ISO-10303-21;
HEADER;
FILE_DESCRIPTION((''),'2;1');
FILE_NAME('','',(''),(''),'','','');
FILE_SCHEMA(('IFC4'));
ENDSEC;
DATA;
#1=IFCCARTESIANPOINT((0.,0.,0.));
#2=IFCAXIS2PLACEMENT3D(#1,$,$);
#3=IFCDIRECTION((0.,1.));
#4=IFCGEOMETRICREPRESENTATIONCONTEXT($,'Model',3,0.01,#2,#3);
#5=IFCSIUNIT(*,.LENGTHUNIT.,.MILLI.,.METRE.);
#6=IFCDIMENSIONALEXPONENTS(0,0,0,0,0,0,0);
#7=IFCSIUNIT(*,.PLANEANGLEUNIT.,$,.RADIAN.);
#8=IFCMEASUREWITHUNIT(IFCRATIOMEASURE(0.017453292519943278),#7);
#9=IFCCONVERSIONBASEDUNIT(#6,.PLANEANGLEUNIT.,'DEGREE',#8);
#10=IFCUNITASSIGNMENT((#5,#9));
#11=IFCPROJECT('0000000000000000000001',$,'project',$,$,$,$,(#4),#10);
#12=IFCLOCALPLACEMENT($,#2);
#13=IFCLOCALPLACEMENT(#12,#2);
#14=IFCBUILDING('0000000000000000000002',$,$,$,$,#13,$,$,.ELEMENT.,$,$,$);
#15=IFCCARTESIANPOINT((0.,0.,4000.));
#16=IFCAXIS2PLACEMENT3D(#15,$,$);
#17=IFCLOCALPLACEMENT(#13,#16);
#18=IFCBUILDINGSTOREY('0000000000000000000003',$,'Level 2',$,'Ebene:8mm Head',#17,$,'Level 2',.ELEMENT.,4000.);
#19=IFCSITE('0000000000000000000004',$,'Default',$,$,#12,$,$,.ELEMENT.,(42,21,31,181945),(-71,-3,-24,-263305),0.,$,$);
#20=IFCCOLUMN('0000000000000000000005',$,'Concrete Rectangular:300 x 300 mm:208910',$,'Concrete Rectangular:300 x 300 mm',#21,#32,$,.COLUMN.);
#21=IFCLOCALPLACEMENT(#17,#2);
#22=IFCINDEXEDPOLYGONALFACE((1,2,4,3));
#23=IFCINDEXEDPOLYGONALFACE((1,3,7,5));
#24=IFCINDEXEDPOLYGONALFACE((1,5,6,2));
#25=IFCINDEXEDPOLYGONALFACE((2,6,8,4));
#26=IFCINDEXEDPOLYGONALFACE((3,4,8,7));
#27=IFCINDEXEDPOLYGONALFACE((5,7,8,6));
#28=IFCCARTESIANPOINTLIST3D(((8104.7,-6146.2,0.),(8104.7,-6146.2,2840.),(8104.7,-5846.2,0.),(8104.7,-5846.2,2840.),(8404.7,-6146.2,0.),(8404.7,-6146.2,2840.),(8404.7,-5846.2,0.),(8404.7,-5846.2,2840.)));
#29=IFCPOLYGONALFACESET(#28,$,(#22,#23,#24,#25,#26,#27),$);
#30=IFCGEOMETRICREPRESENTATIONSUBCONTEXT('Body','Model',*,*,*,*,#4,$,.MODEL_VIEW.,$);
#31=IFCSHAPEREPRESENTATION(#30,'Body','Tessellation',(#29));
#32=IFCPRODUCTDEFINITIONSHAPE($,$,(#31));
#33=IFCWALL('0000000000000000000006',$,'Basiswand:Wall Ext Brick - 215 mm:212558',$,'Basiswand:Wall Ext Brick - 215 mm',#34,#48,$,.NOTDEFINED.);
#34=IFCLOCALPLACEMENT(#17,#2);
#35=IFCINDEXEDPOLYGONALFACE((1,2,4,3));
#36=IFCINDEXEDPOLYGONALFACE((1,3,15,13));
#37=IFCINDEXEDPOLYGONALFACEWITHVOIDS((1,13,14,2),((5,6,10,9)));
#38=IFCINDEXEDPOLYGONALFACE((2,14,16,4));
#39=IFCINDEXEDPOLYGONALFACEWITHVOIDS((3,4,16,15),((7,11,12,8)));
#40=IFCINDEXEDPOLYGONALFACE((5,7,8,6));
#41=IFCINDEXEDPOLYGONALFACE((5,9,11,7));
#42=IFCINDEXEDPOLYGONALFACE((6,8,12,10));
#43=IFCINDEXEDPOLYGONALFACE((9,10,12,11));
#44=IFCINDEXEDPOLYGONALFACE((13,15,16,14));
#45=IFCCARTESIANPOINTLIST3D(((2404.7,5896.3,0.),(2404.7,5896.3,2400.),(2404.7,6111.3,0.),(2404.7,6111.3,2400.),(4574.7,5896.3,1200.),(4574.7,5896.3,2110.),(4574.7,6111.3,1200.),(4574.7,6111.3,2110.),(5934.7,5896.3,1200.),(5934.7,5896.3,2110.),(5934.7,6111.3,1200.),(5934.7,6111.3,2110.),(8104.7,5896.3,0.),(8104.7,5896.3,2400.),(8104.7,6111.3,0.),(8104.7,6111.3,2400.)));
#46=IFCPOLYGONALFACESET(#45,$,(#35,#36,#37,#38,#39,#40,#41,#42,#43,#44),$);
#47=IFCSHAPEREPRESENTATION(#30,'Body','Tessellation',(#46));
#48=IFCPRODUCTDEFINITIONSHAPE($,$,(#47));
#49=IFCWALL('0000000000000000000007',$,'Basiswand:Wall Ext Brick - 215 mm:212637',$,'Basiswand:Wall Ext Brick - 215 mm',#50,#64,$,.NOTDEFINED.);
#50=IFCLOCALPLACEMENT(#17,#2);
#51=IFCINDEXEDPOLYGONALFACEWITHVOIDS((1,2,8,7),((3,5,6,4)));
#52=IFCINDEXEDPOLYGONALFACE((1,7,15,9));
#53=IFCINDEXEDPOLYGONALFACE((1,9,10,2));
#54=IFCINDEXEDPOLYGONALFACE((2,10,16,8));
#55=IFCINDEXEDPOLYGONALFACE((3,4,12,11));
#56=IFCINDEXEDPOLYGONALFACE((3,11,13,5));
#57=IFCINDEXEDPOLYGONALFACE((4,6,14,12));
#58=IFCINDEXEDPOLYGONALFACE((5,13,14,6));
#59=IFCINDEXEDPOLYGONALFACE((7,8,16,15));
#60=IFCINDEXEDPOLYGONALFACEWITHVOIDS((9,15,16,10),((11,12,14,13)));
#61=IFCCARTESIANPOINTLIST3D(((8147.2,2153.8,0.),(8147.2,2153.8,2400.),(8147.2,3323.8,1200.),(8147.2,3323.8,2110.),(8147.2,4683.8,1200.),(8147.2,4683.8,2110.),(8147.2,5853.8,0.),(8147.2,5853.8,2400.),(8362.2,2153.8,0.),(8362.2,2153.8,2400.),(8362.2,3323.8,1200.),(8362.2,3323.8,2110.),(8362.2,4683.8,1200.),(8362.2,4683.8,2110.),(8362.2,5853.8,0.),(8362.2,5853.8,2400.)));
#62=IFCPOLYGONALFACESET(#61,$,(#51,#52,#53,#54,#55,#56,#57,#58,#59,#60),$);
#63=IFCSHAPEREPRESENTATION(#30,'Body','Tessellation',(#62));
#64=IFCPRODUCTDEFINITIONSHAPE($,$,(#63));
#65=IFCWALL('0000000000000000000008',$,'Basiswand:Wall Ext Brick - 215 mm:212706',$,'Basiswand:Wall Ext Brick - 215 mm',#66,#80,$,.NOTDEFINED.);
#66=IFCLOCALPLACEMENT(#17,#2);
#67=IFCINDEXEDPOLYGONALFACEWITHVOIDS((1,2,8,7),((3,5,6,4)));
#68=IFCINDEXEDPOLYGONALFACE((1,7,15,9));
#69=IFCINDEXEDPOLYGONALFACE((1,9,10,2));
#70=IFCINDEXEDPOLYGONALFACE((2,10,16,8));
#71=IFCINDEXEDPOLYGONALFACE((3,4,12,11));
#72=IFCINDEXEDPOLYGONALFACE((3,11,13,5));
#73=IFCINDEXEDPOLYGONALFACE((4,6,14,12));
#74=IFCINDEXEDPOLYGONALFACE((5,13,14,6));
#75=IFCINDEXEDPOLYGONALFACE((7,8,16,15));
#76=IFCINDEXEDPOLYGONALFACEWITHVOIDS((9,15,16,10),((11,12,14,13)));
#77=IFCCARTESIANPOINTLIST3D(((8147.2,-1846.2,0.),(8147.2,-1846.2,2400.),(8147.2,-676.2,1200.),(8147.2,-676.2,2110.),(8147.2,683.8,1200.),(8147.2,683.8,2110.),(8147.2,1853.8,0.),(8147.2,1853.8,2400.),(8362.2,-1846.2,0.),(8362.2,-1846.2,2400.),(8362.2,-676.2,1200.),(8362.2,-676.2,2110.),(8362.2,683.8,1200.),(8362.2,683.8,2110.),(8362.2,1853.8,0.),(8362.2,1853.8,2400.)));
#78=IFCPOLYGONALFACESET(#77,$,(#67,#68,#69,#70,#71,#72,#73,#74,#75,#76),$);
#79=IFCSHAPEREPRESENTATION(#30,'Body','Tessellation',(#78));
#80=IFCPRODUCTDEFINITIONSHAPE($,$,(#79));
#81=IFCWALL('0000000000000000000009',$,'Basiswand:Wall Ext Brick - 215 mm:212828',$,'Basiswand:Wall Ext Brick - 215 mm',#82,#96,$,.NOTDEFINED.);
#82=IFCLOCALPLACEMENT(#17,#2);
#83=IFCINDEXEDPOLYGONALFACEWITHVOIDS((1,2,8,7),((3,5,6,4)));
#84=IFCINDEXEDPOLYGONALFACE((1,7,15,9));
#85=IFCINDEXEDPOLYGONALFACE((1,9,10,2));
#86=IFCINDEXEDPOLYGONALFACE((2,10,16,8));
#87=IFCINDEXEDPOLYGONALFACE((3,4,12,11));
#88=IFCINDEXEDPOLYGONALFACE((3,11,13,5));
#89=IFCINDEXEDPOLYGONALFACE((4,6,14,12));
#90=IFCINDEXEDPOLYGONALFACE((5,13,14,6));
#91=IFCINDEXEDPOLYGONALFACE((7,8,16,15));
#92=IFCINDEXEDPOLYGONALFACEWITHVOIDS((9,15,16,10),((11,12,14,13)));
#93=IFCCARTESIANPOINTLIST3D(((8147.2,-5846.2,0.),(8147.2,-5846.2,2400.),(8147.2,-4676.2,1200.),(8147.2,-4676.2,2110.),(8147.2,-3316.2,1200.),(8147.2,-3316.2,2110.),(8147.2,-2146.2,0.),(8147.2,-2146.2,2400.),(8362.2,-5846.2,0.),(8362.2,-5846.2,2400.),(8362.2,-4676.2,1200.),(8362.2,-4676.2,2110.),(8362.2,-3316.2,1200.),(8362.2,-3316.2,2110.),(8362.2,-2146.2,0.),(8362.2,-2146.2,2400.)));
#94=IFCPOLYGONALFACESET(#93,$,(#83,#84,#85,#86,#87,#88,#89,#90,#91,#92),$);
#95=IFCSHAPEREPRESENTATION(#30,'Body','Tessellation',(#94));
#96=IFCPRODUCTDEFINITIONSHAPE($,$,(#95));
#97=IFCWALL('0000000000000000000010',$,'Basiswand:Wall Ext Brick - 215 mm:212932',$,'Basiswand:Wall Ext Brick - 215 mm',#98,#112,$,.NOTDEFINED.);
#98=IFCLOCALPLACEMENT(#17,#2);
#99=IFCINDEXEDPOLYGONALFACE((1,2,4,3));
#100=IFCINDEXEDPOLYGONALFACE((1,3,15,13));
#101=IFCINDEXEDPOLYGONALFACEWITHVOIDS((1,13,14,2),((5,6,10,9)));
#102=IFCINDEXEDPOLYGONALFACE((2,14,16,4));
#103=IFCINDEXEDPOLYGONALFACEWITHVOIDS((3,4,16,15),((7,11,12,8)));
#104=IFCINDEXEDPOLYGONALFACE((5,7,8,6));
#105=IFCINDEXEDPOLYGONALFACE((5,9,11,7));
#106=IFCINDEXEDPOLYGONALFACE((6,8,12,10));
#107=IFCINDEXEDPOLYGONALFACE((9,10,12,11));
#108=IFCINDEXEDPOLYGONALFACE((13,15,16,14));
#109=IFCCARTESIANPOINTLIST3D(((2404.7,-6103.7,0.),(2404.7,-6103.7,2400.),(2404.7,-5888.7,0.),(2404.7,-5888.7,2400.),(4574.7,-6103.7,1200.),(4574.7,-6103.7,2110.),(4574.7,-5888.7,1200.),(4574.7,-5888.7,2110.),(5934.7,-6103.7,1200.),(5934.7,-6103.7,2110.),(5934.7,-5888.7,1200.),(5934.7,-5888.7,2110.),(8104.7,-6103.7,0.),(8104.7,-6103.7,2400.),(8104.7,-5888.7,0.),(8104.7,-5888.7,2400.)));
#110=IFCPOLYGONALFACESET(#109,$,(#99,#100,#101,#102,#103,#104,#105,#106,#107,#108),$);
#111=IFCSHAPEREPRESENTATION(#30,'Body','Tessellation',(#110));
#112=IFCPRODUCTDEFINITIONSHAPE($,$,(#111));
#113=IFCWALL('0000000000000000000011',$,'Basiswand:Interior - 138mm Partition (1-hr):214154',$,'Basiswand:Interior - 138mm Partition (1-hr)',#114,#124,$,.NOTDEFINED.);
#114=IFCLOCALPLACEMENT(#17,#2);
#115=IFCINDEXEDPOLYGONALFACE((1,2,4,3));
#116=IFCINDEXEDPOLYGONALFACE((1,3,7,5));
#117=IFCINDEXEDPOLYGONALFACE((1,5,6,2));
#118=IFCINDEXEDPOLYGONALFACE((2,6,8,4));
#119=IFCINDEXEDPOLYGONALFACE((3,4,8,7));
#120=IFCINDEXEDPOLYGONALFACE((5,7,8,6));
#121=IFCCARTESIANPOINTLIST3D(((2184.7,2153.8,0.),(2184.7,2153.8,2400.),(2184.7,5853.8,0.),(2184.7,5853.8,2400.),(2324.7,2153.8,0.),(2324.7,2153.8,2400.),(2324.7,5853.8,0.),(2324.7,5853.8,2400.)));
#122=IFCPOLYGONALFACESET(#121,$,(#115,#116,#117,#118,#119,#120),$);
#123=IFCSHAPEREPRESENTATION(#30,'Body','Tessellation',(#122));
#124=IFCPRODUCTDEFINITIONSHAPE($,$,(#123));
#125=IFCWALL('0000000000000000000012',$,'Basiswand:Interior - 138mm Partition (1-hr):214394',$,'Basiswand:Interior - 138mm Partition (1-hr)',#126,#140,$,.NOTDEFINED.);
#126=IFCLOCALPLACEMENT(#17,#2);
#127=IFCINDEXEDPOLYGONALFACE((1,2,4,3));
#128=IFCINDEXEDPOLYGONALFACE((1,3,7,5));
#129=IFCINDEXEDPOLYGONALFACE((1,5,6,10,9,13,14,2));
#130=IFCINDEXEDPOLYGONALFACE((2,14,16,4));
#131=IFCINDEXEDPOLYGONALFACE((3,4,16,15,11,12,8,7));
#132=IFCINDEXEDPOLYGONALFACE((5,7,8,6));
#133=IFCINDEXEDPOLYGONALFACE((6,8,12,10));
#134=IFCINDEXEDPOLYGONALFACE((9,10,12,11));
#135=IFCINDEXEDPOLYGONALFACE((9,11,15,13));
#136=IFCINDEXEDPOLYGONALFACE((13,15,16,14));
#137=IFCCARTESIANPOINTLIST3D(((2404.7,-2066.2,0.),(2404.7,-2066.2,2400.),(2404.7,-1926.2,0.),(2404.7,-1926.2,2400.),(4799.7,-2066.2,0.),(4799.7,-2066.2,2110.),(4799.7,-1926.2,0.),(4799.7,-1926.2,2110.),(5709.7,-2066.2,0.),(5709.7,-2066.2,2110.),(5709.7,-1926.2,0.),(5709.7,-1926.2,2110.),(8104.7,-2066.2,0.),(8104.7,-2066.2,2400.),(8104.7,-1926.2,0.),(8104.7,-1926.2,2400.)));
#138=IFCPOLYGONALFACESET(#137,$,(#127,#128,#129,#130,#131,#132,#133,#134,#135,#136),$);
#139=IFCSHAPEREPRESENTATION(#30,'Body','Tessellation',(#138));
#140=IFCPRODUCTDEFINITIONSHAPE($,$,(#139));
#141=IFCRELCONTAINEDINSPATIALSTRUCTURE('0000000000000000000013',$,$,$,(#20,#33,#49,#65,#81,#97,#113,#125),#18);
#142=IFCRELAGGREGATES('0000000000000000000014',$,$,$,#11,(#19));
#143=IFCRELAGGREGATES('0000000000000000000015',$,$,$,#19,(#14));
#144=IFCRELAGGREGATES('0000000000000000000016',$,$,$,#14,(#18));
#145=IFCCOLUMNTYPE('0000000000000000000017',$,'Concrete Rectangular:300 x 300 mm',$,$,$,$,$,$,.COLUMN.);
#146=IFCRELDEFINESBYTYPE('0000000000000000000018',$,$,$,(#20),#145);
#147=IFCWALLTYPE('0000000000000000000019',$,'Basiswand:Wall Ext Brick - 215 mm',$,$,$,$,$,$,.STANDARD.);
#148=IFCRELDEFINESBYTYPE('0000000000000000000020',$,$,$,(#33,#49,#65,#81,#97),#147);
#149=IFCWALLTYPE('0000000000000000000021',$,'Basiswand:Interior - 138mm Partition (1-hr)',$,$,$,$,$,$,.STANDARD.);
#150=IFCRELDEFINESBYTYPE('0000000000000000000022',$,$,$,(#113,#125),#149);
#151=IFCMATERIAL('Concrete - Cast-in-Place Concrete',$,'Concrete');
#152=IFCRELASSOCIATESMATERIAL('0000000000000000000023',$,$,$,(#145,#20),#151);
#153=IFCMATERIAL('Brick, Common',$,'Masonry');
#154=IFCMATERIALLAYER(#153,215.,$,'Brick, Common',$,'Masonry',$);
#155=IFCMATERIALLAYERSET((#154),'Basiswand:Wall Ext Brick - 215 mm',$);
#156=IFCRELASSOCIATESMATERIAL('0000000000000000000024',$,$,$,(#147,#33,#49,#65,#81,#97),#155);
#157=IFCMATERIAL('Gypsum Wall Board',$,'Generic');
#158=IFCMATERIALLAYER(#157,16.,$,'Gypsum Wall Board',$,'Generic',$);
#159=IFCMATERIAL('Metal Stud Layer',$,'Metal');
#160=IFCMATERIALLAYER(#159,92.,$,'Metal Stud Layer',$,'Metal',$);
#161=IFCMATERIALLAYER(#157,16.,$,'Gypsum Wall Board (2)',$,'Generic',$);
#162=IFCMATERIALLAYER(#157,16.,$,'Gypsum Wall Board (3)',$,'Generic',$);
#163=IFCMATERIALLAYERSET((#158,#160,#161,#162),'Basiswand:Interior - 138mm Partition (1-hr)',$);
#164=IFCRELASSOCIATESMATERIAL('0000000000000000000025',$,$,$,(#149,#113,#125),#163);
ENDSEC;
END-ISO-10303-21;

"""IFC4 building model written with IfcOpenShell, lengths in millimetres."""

from ifc_helpers import new_model, entity, si_unit, converted_unit, direction, frame, frame_2d, origin, place, context, subcontext, project, spatial, polyline, segment, composite_curve, rectangle, outline, extrude, source, transform, mapped, material, layer, layer_set, layer_usage, material_profile, profile_set, profile_usage, type_object, type_shapes, element, save


model = new_model("IFC4")

# Units and contexts
model_context = context("Model", 3, precision=0.01, world=origin(), true_north=direction((0.0, 1.0)))
body_context = subcontext(model_context, "Body", "Model", "MODEL_VIEW")
ifc_project = project(units=[si_unit("LENGTHUNIT", "METRE", prefix="MILLI"), converted_unit("PLANEANGLEUNIT", "DEGREE", entity("IfcRatioMeasure", 0.017453292519943278), si_unit("PLANEANGLEUNIT", "RADIAN"), dimensions=[0, 0, 0, 0, 0, 0, 0])], contexts=[model_context])

# Site, building, storey
site_placement = place(None, origin())
site = spatial("IfcSite", under=ifc_project, at=site_placement, Name="Default", CompositionType="ELEMENT", RefLatitude=(42, 21, 31, 181945), RefLongitude=(-71, -3, -24, -263305), RefElevation=0.0)
building_placement = place(site_placement, origin())
building = spatial("IfcBuilding", under=site, at=building_placement, CompositionType="ELEMENT")
storey_placement = place(building_placement, frame((0.0, 0.0, 4000.0)))
storey = spatial("IfcBuildingStorey", under=building, at=storey_placement, Name="Level 2", ObjectType="Ebene:8mm Head", LongName="Level 2", CompositionType="ELEMENT", Elevation=4000.0)

# Column
ifc_material_1 = material(Name="Concrete - Cast-in-Place Concrete", Category="Concrete")
ifc_material_profile_1 = material_profile(ifc_material_1, outline(composite_curve([segment(polyline([(150.0, 150.0, 0.0), (150.0, -150.0, 0.0)]), True, "CONTINUOUS"), segment(polyline([(150.0, -150.0, 0.0), (-150.0, -150.0, 0.0)]), True, "CONTINUOUS"), segment(polyline([(-150.0, -150.0, 0.0), (-150.0, 150.0, 0.0)]), True, "CONTINUOUS"), segment(polyline([(-150.0, 150.0, 0.0), (150.0, 150.0, 0.0)]), True, "CONTINUOUS")], self_intersect=False), kind="CURVE"), Name="300 x 300 mm")
ifc_material_profile_2 = material_profile(ifc_material_1, outline(composite_curve([segment(polyline([(150.0, 150.0, 4000.0), (-150.0, 150.0, 4000.0)]), True, "CONTINUOUS"), segment(polyline([(-150.0, 150.0, 4000.0), (-150.0, -150.0, 4000.0)]), True, "CONTINUOUS"), segment(polyline([(-150.0, -150.0, 4000.0), (150.0, -150.0, 4000.0)]), True, "CONTINUOUS"), segment(polyline([(150.0, -150.0, 4000.0), (150.0, 150.0, 4000.0)]), True, "CONTINUOUS")], self_intersect=False), kind="CURVE"), Name="300 x 300 mm")
ifc_profile_set = profile_set([ifc_material_profile_1, ifc_material_profile_2], Name="300 x 300 mm")
ifc_profile_usage_1 = profile_usage(ifc_profile_set)
column_type_1 = type_object("IfcColumnType", Name="Concrete Rectangular:300 x 300 mm", PredefinedType="COLUMN", material=ifc_profile_set)
shared_shape_1 = source(origin(), body_context, "Body", "SweptSolid", [
    extrude(rectangle(XDim=300.0, YDim=300.0, at=frame_2d((0.0, 0.0), x_axis=(1.0, 0.0))), frame((8254.7, -5996.2, 4000.0), z_axis=(0.0, 0.0, 1.0), x_axis=(0.0, -1.0, 0.0)), (0.0, 0.0, 1.0), 2840.0),
])
type_shapes(column_type_1, [shared_shape_1])
column_1_placement = place(storey_placement, frame((0.0, 0.0, -4000.0)))
element("IfcColumn", 1, at=column_1_placement, inside=storey, type_object=column_type_1, material=ifc_profile_usage_1, Name="Concrete Rectangular:300 x 300 mm:208910", ObjectType="Concrete Rectangular:300 x 300 mm", PredefinedType="COLUMN", context=body_context, shape_type="MappedRepresentation", body=[
    mapped(shared_shape_1, transform((0.0, 0.0, 0.0), scale=1.0)),
])

# Walls, openings
ifc_material_2 = material(Name="Brick, Common", Category="Masonry")
ifc_layer_1 = layer(ifc_material_2, 215.0, Name="Brick, Common", Category="Masonry")
ifc_layer_set_1 = layer_set([ifc_layer_1], Name="Basiswand:Wall Ext Brick - 215 mm")
ifc_layer_usage_1 = layer_usage(ifc_layer_set_1, "AXIS2", "NEGATIVE", 107.5)
wall_type_1 = type_object("IfcWallType", Name="Basiswand:Wall Ext Brick - 215 mm", PredefinedType="STANDARD", material=ifc_layer_set_1)
wall_1_placement = place(storey_placement, frame((2404.7, 6003.8, 0.0)))
wall_1 = element("IfcWall", 2, at=wall_1_placement, inside=storey, type_object=wall_type_1, material=ifc_layer_usage_1, Name="Basiswand:Wall Ext Brick - 215 mm:212558", ObjectType="Basiswand:Wall Ext Brick - 215 mm", PredefinedType="NOTDEFINED", context=body_context, shape_type="SweptSolid", body=[
    extrude(rectangle(XDim=5700.0, YDim=215.0, at=frame_2d((2850.0, 0.0), x_axis=(-1.0, 0.0))), origin(), (0.0, 0.0, 1.0), 2400.0),
])
opening_1_placement = place(wall_1_placement, frame((2170.0, -107.5, 1200.0)))
element("IfcOpeningElement", 3, at=opening_1_placement, cuts=wall_1, PredefinedType="OPENING", context=body_context, shape_type="SweptSolid", body=[
    extrude(rectangle(XDim=910.0, YDim=1360.0, at=frame_2d((455.0, 680.0), x_axis=(-1.0, 0.0))), frame((0.0, 0.0, 0.0), z_axis=(0.0, 1.0, 0.0), x_axis=(0.0, 0.0, 1.0)), (0.0, 0.0, 1.0), 215.0),
])
ifc_layer_usage_2 = layer_usage(ifc_layer_set_1, "AXIS2", "NEGATIVE", 107.5)
wall_2_placement = place(storey_placement, frame((8254.7, 5853.8, 0.0), z_axis=(0.0, 0.0, 1.0), x_axis=(0.0, -1.0, 0.0)))
wall_2 = element("IfcWall", 4, at=wall_2_placement, inside=storey, type_object=wall_type_1, material=ifc_layer_usage_2, Name="Basiswand:Wall Ext Brick - 215 mm:212637", ObjectType="Basiswand:Wall Ext Brick - 215 mm", PredefinedType="NOTDEFINED", context=body_context, shape_type="SweptSolid", body=[
    extrude(rectangle(XDim=3700.0, YDim=215.0, at=frame_2d((1850.0, 0.0), x_axis=(-1.0, 0.0))), origin(), (0.0, 0.0, 1.0), 2400.0),
])
opening_2_placement = place(wall_2_placement, frame((1170.0, -107.5, 1200.0)))
element("IfcOpeningElement", 5, at=opening_2_placement, cuts=wall_2, PredefinedType="OPENING", context=body_context, shape_type="SweptSolid", body=[
    extrude(rectangle(XDim=910.0, YDim=1360.0, at=frame_2d((455.0, 680.0), x_axis=(-1.0, 0.0))), frame((0.0, 0.0, 0.0), z_axis=(0.0, 1.0, 0.0), x_axis=(0.0, 0.0, 1.0)), (0.0, 0.0, 1.0), 215.0),
])
ifc_layer_usage_3 = layer_usage(ifc_layer_set_1, "AXIS2", "NEGATIVE", 107.5)
wall_3_placement = place(storey_placement, frame((8254.7, 1853.8, 0.0), z_axis=(0.0, 0.0, 1.0), x_axis=(0.0, -1.0, 0.0)))
wall_3 = element("IfcWall", 6, at=wall_3_placement, inside=storey, type_object=wall_type_1, material=ifc_layer_usage_3, Name="Basiswand:Wall Ext Brick - 215 mm:212706", ObjectType="Basiswand:Wall Ext Brick - 215 mm", PredefinedType="NOTDEFINED", context=body_context, shape_type="SweptSolid", body=[
    extrude(rectangle(XDim=3700.0, YDim=215.0, at=frame_2d((1850.0, 0.0), x_axis=(-1.0, 0.0))), origin(), (0.0, 0.0, 1.0), 2400.0),
])
opening_3_placement = place(wall_3_placement, frame((1170.0, -107.5, 1200.0)))
element("IfcOpeningElement", 7, at=opening_3_placement, cuts=wall_3, PredefinedType="OPENING", context=body_context, shape_type="SweptSolid", body=[
    extrude(rectangle(XDim=910.0, YDim=1360.0, at=frame_2d((455.0, 680.0), x_axis=(-1.0, 0.0))), frame((0.0, 0.0, 0.0), z_axis=(0.0, 1.0, 0.0), x_axis=(0.0, 0.0, 1.0)), (0.0, 0.0, 1.0), 215.0),
])
ifc_layer_usage_4 = layer_usage(ifc_layer_set_1, "AXIS2", "NEGATIVE", 107.5)
wall_4_placement = place(storey_placement, frame((8254.7, -2146.2, 0.0), z_axis=(0.0, 0.0, 1.0), x_axis=(0.0, -1.0, 0.0)))
wall_4 = element("IfcWall", 8, at=wall_4_placement, inside=storey, type_object=wall_type_1, material=ifc_layer_usage_4, Name="Basiswand:Wall Ext Brick - 215 mm:212828", ObjectType="Basiswand:Wall Ext Brick - 215 mm", PredefinedType="NOTDEFINED", context=body_context, shape_type="SweptSolid", body=[
    extrude(rectangle(XDim=3700.0, YDim=215.0, at=frame_2d((1850.0, 0.0), x_axis=(-1.0, 0.0))), origin(), (0.0, 0.0, 1.0), 2400.0),
])
opening_4_placement = place(wall_4_placement, frame((2530.0, 107.5, 1200.0)))
element("IfcOpeningElement", 9, at=opening_4_placement, cuts=wall_4, PredefinedType="OPENING", context=body_context, shape_type="SweptSolid", body=[
    extrude(rectangle(XDim=910.0, YDim=1360.0, at=frame_2d((455.0, 680.0), x_axis=(-1.0, 0.0))), frame((0.0, 0.0, 0.0), z_axis=(0.0, -1.0, 0.0), x_axis=(0.0, 0.0, 1.0)), (0.0, 0.0, 1.0), 215.0),
])
ifc_layer_usage_5 = layer_usage(ifc_layer_set_1, "AXIS2", "NEGATIVE", 107.5)
wall_5_placement = place(storey_placement, frame((2404.7, -5996.2, 0.0)))
wall_5 = element("IfcWall", 10, at=wall_5_placement, inside=storey, type_object=wall_type_1, material=ifc_layer_usage_5, Name="Basiswand:Wall Ext Brick - 215 mm:212932", ObjectType="Basiswand:Wall Ext Brick - 215 mm", PredefinedType="NOTDEFINED", context=body_context, shape_type="SweptSolid", body=[
    extrude(rectangle(XDim=5700.0, YDim=215.0, at=frame_2d((2850.0, 0.0), x_axis=(-1.0, 0.0))), origin(), (0.0, 0.0, 1.0), 2400.0),
])
opening_5_placement = place(wall_5_placement, frame((2170.0, -107.5, 1200.0)))
element("IfcOpeningElement", 11, at=opening_5_placement, cuts=wall_5, PredefinedType="OPENING", context=body_context, shape_type="SweptSolid", body=[
    extrude(rectangle(XDim=910.0, YDim=1360.0, at=frame_2d((455.0, 680.0), x_axis=(-1.0, 0.0))), frame((0.0, 0.0, 0.0), z_axis=(0.0, 1.0, 0.0), x_axis=(0.0, 0.0, 1.0)), (0.0, 0.0, 1.0), 215.0),
])

# Wall
ifc_material_3 = material(Name="Gypsum Wall Board", Category="Generic")
ifc_layer_2 = layer(ifc_material_3, 16.0, Name="Gypsum Wall Board", Category="Generic")
ifc_material_4 = material(Name="Metal Stud Layer", Category="Metal")
ifc_layer_3 = layer(ifc_material_4, 92.0, Name="Metal Stud Layer", Category="Metal")
ifc_layer_4 = layer(ifc_material_3, 16.0, Name="Gypsum Wall Board (2)", Category="Generic")
ifc_layer_5 = layer(ifc_material_3, 16.0, Name="Gypsum Wall Board (3)", Category="Generic")
ifc_layer_set_2 = layer_set([ifc_layer_2, ifc_layer_3, ifc_layer_4, ifc_layer_5], Name="Basiswand:Interior - 138mm Partition (1-hr)")
ifc_layer_usage_6 = layer_usage(ifc_layer_set_2, "AXIS2", "NEGATIVE", 70.0)
wall_type_2 = type_object("IfcWallType", Name="Basiswand:Interior - 138mm Partition (1-hr)", PredefinedType="STANDARD", material=ifc_layer_set_2)
wall_6_placement = place(storey_placement, frame((2254.7, 2153.8, 0.0), z_axis=(0.0, 0.0, 1.0), x_axis=(0.0, 1.0, 0.0)))
element("IfcWall", 12, at=wall_6_placement, inside=storey, type_object=wall_type_2, material=ifc_layer_usage_6, Name="Basiswand:Interior - 138mm Partition (1-hr):214154", ObjectType="Basiswand:Interior - 138mm Partition (1-hr)", PredefinedType="NOTDEFINED", context=body_context, shape_type="SweptSolid", body=[
    extrude(rectangle(XDim=3700.0, YDim=140.0, at=frame_2d((1850.0, 0.0), x_axis=(-1.0, 0.0))), origin(), (0.0, 0.0, 1.0), 2400.0),
])

# Wall, opening
ifc_layer_usage_7 = layer_usage(ifc_layer_set_2, "AXIS2", "NEGATIVE", 70.0)
wall_7_placement = place(storey_placement, frame((2404.7, -1996.2, 0.0)))
wall_7 = element("IfcWall", 13, at=wall_7_placement, inside=storey, type_object=wall_type_2, material=ifc_layer_usage_7, Name="Basiswand:Interior - 138mm Partition (1-hr):214394", ObjectType="Basiswand:Interior - 138mm Partition (1-hr)", PredefinedType="NOTDEFINED", context=body_context, shape_type="SweptSolid", body=[
    extrude(rectangle(XDim=5700.0, YDim=140.0, at=frame_2d((2850.0, 0.0), x_axis=(1.0, 0.0))), origin(), (0.0, 0.0, 1.0), 2400.0),
])
opening_6_placement = place(wall_7_placement, frame((3305.0, 70.0, 0.0)))
element("IfcOpeningElement", 14, at=opening_6_placement, cuts=wall_7, PredefinedType="OPENING", context=body_context, shape_type="SweptSolid", body=[
    extrude(rectangle(XDim=2110.0, YDim=910.0, at=frame_2d((1055.0, 455.0), x_axis=(1.0, 0.0))), frame((0.0, 0.0, 0.0), z_axis=(0.0, -1.0, 0.0), x_axis=(0.0, 0.0, 1.0)), (0.0, 0.0, 1.0), 140.0),
])

save(model, "model.ifc")
